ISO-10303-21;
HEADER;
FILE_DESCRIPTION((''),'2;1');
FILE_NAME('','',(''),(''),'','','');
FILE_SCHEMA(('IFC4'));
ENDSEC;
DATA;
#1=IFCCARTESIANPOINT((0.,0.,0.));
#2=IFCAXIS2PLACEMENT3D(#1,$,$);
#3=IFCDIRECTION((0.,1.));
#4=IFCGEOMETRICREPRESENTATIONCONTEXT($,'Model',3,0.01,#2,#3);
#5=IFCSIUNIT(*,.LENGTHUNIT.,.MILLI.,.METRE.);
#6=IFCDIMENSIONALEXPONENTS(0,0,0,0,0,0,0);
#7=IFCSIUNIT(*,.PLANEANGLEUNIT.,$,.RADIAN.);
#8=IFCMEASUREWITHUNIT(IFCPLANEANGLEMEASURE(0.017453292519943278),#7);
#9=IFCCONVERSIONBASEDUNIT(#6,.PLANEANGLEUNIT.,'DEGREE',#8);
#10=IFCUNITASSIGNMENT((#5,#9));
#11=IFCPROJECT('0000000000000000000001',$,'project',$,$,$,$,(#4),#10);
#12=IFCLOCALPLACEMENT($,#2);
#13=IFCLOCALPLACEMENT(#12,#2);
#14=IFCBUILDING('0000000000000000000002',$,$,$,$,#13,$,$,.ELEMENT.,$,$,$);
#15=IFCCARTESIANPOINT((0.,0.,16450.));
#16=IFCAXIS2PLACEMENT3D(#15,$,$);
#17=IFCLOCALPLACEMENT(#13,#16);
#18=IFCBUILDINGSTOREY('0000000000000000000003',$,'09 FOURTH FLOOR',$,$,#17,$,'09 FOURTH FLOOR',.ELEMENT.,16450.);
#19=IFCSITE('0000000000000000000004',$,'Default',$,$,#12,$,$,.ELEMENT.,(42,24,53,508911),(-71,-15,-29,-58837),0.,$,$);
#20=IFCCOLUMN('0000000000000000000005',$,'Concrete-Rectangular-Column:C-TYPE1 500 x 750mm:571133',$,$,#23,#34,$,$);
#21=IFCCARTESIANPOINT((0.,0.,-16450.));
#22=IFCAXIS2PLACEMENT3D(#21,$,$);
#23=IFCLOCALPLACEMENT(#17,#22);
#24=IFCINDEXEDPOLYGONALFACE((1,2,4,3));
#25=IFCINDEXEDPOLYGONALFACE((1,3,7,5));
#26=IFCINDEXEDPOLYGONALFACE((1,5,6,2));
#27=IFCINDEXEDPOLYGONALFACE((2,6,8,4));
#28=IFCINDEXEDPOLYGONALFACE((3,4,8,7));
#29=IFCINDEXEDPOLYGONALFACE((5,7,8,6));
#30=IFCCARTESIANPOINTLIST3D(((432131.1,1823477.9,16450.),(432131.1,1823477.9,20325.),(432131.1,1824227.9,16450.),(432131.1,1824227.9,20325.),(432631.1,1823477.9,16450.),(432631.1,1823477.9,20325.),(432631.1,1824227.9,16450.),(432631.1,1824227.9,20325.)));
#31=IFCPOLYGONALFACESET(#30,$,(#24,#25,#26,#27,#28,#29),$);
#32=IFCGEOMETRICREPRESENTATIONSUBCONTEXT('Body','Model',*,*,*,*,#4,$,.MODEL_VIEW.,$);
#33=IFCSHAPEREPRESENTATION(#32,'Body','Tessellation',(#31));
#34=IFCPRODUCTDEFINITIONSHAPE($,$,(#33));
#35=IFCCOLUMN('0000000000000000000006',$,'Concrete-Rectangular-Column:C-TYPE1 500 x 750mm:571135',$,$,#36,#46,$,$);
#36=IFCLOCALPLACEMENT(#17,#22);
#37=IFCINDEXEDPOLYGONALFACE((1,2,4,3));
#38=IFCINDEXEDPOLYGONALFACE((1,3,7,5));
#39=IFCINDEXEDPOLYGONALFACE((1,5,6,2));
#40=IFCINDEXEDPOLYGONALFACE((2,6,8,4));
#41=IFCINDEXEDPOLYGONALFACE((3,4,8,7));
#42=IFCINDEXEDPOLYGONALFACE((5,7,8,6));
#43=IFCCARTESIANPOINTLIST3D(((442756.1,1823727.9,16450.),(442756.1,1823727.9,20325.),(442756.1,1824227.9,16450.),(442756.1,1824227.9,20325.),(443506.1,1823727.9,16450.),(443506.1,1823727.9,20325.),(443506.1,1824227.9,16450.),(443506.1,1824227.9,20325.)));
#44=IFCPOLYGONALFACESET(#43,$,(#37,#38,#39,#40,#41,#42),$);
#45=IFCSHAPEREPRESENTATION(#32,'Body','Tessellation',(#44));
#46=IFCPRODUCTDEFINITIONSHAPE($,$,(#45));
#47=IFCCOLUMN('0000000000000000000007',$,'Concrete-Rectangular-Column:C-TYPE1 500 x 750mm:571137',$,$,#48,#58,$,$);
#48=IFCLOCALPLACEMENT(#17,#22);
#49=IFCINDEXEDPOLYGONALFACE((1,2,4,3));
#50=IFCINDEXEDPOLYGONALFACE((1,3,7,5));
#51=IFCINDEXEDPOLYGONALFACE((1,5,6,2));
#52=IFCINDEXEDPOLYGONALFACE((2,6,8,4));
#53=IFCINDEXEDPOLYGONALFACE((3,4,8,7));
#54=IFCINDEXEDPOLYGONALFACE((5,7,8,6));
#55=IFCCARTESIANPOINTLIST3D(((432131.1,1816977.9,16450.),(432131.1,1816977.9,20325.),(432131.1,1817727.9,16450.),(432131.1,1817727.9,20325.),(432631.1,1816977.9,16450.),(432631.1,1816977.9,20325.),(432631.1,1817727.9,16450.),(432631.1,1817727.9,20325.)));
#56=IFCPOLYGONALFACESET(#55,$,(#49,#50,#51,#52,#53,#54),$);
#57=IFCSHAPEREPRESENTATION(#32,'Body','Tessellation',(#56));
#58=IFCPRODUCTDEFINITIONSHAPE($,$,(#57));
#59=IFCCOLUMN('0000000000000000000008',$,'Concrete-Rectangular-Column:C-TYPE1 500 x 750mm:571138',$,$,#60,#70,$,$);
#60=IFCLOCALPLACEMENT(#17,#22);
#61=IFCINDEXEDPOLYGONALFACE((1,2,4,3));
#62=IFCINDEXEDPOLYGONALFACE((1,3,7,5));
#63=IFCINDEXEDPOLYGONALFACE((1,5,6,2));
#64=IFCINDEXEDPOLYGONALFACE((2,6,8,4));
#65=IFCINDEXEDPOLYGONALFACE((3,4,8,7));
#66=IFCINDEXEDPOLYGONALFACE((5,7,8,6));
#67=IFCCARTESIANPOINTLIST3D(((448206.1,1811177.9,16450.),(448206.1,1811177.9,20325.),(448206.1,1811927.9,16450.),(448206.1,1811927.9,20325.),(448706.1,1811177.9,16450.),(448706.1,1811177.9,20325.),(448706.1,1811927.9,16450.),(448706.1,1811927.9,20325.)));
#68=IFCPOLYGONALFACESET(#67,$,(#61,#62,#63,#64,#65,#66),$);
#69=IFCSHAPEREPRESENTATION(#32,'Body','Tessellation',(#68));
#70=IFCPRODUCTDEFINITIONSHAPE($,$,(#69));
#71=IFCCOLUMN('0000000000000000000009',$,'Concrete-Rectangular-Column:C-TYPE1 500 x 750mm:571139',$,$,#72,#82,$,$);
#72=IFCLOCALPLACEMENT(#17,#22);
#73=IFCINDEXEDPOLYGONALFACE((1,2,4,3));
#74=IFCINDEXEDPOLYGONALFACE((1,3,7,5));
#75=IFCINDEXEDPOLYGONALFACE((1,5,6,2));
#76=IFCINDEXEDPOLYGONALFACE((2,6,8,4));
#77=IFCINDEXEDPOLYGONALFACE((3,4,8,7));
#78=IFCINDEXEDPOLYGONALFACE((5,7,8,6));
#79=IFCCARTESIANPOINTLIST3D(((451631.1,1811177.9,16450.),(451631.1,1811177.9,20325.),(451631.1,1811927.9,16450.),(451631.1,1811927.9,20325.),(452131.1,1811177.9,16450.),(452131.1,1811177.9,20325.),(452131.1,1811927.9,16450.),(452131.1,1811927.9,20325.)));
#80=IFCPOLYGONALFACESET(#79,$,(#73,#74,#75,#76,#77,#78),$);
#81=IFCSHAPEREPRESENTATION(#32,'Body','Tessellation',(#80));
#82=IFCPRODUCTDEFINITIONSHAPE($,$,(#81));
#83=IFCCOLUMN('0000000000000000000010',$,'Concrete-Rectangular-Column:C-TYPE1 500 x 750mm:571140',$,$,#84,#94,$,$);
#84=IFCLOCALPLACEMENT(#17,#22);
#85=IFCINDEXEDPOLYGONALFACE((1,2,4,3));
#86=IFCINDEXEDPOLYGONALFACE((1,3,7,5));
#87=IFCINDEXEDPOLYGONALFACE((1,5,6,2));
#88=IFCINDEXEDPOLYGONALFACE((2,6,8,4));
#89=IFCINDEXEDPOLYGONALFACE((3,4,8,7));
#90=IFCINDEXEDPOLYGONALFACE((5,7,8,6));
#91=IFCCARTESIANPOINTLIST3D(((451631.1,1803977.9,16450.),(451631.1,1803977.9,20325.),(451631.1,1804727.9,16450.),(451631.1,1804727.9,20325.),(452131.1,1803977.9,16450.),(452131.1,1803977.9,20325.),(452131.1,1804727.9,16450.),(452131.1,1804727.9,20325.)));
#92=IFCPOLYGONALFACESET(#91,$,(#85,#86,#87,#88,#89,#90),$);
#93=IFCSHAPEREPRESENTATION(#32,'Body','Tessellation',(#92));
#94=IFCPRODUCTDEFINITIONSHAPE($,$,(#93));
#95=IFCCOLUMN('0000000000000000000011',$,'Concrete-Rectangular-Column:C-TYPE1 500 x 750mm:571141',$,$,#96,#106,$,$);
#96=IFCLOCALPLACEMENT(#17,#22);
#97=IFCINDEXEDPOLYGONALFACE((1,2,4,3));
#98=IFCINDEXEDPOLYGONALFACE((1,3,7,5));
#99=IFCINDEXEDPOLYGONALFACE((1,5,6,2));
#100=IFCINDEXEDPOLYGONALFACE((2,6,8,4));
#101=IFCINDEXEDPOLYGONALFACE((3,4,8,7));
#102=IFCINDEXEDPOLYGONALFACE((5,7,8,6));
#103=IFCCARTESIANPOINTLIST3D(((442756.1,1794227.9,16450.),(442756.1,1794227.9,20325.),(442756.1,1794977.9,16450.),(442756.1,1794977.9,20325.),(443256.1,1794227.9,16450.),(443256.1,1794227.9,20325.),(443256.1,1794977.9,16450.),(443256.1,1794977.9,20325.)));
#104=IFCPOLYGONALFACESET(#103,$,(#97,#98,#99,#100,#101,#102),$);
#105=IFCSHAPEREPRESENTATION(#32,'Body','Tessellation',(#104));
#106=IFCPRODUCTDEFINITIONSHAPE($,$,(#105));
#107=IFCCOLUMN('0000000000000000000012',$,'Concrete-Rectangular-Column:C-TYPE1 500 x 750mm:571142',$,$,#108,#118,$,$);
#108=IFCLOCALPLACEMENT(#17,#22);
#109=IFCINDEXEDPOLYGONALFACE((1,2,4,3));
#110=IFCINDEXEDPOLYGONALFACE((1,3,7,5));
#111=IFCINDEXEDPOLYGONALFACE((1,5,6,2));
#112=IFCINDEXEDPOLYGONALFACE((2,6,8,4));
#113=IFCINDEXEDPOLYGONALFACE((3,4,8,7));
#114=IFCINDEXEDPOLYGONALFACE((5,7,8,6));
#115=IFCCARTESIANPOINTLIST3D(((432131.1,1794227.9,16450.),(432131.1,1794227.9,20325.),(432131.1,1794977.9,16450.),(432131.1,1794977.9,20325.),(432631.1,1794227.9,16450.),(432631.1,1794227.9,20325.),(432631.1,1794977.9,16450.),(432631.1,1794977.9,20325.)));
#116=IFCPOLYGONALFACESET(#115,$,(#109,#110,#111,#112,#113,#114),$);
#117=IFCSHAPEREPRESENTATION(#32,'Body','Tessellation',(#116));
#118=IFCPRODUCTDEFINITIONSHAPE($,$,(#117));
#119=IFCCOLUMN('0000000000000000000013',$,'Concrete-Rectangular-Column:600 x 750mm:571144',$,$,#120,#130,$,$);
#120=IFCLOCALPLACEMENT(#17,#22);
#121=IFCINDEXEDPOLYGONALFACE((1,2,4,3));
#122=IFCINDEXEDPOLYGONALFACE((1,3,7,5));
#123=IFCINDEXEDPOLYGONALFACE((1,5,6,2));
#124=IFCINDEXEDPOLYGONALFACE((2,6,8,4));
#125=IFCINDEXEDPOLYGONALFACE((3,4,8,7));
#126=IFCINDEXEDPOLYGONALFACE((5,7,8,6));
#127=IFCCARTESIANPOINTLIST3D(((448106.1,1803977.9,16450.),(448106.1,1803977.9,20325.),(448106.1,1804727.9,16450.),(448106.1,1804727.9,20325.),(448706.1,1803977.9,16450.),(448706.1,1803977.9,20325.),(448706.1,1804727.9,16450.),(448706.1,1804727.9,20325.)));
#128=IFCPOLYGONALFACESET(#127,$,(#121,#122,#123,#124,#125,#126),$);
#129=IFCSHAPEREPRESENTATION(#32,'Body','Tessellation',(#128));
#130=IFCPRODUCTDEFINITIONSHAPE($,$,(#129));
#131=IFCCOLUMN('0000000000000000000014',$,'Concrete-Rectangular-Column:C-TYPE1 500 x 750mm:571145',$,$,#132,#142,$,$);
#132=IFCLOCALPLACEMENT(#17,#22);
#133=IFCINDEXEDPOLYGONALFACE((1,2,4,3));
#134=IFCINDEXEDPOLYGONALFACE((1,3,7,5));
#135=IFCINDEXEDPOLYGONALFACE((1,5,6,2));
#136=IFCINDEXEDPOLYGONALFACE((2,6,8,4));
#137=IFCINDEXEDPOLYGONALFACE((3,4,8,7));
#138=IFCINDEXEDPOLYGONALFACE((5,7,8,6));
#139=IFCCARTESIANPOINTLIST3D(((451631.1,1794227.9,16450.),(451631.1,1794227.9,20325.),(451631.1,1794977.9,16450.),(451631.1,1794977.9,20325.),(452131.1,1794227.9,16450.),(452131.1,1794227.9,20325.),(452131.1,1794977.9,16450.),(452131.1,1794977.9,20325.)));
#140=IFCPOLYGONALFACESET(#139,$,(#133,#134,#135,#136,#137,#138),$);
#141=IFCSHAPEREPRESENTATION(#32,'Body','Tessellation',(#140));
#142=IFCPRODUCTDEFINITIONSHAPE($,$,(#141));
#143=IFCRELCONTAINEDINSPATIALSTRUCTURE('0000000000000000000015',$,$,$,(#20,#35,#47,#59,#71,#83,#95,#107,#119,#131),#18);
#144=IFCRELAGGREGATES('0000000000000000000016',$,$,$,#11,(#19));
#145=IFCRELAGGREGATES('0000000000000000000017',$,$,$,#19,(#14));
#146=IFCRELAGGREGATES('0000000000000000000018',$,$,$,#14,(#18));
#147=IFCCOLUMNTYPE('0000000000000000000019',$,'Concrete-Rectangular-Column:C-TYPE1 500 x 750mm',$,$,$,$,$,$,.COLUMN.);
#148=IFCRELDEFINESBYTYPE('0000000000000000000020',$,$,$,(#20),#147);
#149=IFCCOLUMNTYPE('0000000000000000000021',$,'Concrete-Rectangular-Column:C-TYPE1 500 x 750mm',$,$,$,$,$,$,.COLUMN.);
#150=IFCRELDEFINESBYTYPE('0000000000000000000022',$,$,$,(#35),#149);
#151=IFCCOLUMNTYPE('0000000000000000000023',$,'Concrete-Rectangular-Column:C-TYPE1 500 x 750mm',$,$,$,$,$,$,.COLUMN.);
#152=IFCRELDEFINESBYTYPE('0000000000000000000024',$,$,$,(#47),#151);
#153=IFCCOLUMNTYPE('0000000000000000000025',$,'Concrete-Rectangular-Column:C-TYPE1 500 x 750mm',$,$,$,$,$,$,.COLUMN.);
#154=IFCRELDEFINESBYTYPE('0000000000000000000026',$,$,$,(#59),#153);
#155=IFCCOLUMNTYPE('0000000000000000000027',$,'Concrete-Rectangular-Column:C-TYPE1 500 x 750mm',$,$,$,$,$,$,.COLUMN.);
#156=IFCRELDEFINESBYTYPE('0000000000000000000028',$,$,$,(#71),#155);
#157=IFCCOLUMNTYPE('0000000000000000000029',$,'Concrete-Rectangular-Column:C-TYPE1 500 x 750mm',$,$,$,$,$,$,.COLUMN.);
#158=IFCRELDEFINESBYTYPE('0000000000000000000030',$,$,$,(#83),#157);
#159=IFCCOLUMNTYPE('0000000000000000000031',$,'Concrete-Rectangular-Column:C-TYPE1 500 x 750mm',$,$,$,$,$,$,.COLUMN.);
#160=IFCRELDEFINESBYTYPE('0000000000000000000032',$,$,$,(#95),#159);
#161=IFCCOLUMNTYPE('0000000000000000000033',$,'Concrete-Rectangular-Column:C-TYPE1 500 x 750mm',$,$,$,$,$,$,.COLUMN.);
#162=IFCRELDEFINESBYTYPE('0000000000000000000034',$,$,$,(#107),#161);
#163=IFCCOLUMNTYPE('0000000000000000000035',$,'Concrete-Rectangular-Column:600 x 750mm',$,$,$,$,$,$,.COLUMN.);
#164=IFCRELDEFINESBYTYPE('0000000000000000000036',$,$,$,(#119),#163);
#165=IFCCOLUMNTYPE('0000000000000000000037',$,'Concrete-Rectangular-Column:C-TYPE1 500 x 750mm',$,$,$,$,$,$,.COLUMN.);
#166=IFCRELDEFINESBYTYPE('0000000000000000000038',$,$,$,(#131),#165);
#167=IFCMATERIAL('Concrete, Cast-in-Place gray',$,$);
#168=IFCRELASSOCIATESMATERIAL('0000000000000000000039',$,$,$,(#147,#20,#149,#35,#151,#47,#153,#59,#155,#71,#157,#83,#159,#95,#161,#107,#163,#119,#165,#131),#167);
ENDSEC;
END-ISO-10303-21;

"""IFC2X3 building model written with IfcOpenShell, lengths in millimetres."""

from ifc_helpers import new_model, entity, si_unit, converted_unit, direction, frame, frame_2d, origin, place, context, subcontext, project, spatial, rectangle, extrude, source, transform, mapped, material, type_object, type_shapes, element, save


model = new_model("IFC2X3")

# Units and contexts
model_context = context("Model", 3, precision=0.01, world=origin(), true_north=direction((0.0, 1.0)))
body_context = subcontext(model_context, "Body", "Model", "MODEL_VIEW")
ifc_project = project(units=[si_unit("LENGTHUNIT", "METRE", prefix="MILLI"), converted_unit("PLANEANGLEUNIT", "DEGREE", entity("IfcPlaneAngleMeasure", 0.017453292519943278), si_unit("PLANEANGLEUNIT", "RADIAN"), dimensions=[0, 0, 0, 0, 0, 0, 0])], contexts=[model_context])

# Site, building, storey
site_placement = place(None, origin())
site = spatial("IfcSite", under=ifc_project, at=site_placement, Name="Default", CompositionType="ELEMENT", RefLatitude=(42, 24, 53, 508911), RefLongitude=(-71, -15, -29, -58837), RefElevation=0.0)
building_placement = place(site_placement, origin())
building = spatial("IfcBuilding", under=site, at=building_placement, CompositionType="ELEMENT")
storey_placement = place(building_placement, frame((0.0, 0.0, 16450.0)))
storey = spatial("IfcBuildingStorey", under=building, at=storey_placement, Name="09 FOURTH FLOOR", LongName="09 FOURTH FLOOR", CompositionType="ELEMENT", Elevation=16450.0)

# Columns
ifc_material = material(Name="Concrete, Cast-in-Place gray")
column_type_1 = type_object("IfcColumnType", Name="Concrete-Rectangular-Column:C-TYPE1 500 x 750mm", PredefinedType="COLUMN", material=ifc_material)
shared_shape_1 = source(origin(), body_context, "Body", "SweptSolid", [
    extrude(rectangle(XDim=3875.0, YDim=750.0, at=frame_2d((0.0, 0.0), x_axis=(1.0, 0.0))), frame((432131.1, 1823852.9, 18387.5), z_axis=(1.0, 0.0, 0.0), x_axis=(0.0, 0.0, 1.0)), (0.0, 0.0, 1.0), 500.0),
])
type_shapes(column_type_1, [shared_shape_1])
column_1_placement = place(storey_placement, frame((0.0, 0.0, -16450.0)))
element("IfcColumn", 1, at=column_1_placement, inside=storey, type_object=column_type_1, material=ifc_material, Name="Concrete-Rectangular-Column:C-TYPE1 500 x 750mm:571133", context=body_context, shape_type="MappedRepresentation", body=[
    mapped(shared_shape_1, transform((0.0, 0.0, 0.0), scale=1.0)),
])
column_type_2 = type_object("IfcColumnType", Name="Concrete-Rectangular-Column:C-TYPE1 500 x 750mm", PredefinedType="COLUMN", material=ifc_material)
shared_shape_2 = source(origin(), body_context, "Body", "SweptSolid", [
    extrude(rectangle(XDim=500.0, YDim=750.0, at=frame_2d((0.0, 0.0), x_axis=(1.0, 0.0))), frame((443131.1, 1823977.9, 16450.0), z_axis=(0.0, 0.0, 1.0), x_axis=(0.0, -1.0, 0.0)), (0.0, 0.0, 1.0), 3875.0),
])
type_shapes(column_type_2, [shared_shape_2])
column_2_placement = place(storey_placement, frame((0.0, 0.0, -16450.0)))
element("IfcColumn", 2, at=column_2_placement, inside=storey, type_object=column_type_2, material=ifc_material, Name="Concrete-Rectangular-Column:C-TYPE1 500 x 750mm:571135", context=body_context, shape_type="MappedRepresentation", body=[
    mapped(shared_shape_2, transform((0.0, 0.0, 0.0), scale=1.0)),
])
column_type_3 = type_object("IfcColumnType", Name="Concrete-Rectangular-Column:C-TYPE1 500 x 750mm", PredefinedType="COLUMN", material=ifc_material)
shared_shape_3 = source(origin(), body_context, "Body", "SweptSolid", [
    extrude(rectangle(XDim=3875.0, YDim=750.0, at=frame_2d((0.0, 0.0), x_axis=(1.0, 0.0))), frame((432131.1, 1817352.9, 18387.5), z_axis=(1.0, 0.0, 0.0), x_axis=(0.0, 0.0, 1.0)), (0.0, 0.0, 1.0), 500.0),
])
type_shapes(column_type_3, [shared_shape_3])
column_3_placement = place(storey_placement, frame((0.0, 0.0, -16450.0)))
element("IfcColumn", 3, at=column_3_placement, inside=storey, type_object=column_type_3, material=ifc_material, Name="Concrete-Rectangular-Column:C-TYPE1 500 x 750mm:571137", context=body_context, shape_type="MappedRepresentation", body=[
    mapped(shared_shape_3, transform((0.0, 0.0, 0.0), scale=1.0)),
])
column_type_4 = type_object("IfcColumnType", Name="Concrete-Rectangular-Column:C-TYPE1 500 x 750mm", PredefinedType="COLUMN", material=ifc_material)
shared_shape_4 = source(origin(), body_context, "Body", "SweptSolid", [
    extrude(rectangle(XDim=3875.0, YDim=750.0, at=frame_2d((0.0, 0.0), x_axis=(1.0, 0.0))), frame((448206.1, 1811552.9, 18387.5), z_axis=(1.0, 0.0, 0.0), x_axis=(0.0, 0.0, 1.0)), (0.0, 0.0, 1.0), 500.0),
])
type_shapes(column_type_4, [shared_shape_4])
column_4_placement = place(storey_placement, frame((0.0, 0.0, -16450.0)))
element("IfcColumn", 4, at=column_4_placement, inside=storey, type_object=column_type_4, material=ifc_material, Name="Concrete-Rectangular-Column:C-TYPE1 500 x 750mm:571138", context=body_context, shape_type="MappedRepresentation", body=[
    mapped(shared_shape_4, transform((0.0, 0.0, 0.0), scale=1.0)),
])
column_type_5 = type_object("IfcColumnType", Name="Concrete-Rectangular-Column:C-TYPE1 500 x 750mm", PredefinedType="COLUMN", material=ifc_material)
shared_shape_5 = source(origin(), body_context, "Body", "SweptSolid", [
    extrude(rectangle(XDim=3875.0, YDim=750.0, at=frame_2d((0.0, 0.0), x_axis=(1.0, 0.0))), frame((451631.1, 1811552.9, 18387.5), z_axis=(1.0, 0.0, 0.0), x_axis=(0.0, 0.0, 1.0)), (0.0, 0.0, 1.0), 500.0),
])
type_shapes(column_type_5, [shared_shape_5])
column_5_placement = place(storey_placement, frame((0.0, 0.0, -16450.0)))
element("IfcColumn", 5, at=column_5_placement, inside=storey, type_object=column_type_5, material=ifc_material, Name="Concrete-Rectangular-Column:C-TYPE1 500 x 750mm:571139", context=body_context, shape_type="MappedRepresentation", body=[
    mapped(shared_shape_5, transform((0.0, 0.0, 0.0), scale=1.0)),
])
column_type_6 = type_object("IfcColumnType", Name="Concrete-Rectangular-Column:C-TYPE1 500 x 750mm", PredefinedType="COLUMN", material=ifc_material)
shared_shape_6 = source(origin(), body_context, "Body", "SweptSolid", [
    extrude(rectangle(XDim=3875.0, YDim=750.0, at=frame_2d((0.0, 0.0), x_axis=(1.0, 0.0))), frame((451631.1, 1804352.9, 18387.5), z_axis=(1.0, 0.0, 0.0), x_axis=(0.0, 0.0, 1.0)), (0.0, 0.0, 1.0), 500.0),
])
type_shapes(column_type_6, [shared_shape_6])
column_6_placement = place(storey_placement, frame((0.0, 0.0, -16450.0)))
element("IfcColumn", 6, at=column_6_placement, inside=storey, type_object=column_type_6, material=ifc_material, Name="Concrete-Rectangular-Column:C-TYPE1 500 x 750mm:571140", context=body_context, shape_type="MappedRepresentation", body=[
    mapped(shared_shape_6, transform((0.0, 0.0, 0.0), scale=1.0)),
])
column_type_7 = type_object("IfcColumnType", Name="Concrete-Rectangular-Column:C-TYPE1 500 x 750mm", PredefinedType="COLUMN", material=ifc_material)
shared_shape_7 = source(origin(), body_context, "Body", "SweptSolid", [
    extrude(rectangle(XDim=3875.0, YDim=750.0, at=frame_2d((0.0, 0.0), x_axis=(1.0, 0.0))), frame((442756.1, 1794602.9, 18387.5), z_axis=(1.0, 0.0, 0.0), x_axis=(0.0, 0.0, 1.0)), (0.0, 0.0, 1.0), 500.0),
])
type_shapes(column_type_7, [shared_shape_7])
column_7_placement = place(storey_placement, frame((0.0, 0.0, -16450.0)))
element("IfcColumn", 7, at=column_7_placement, inside=storey, type_object=column_type_7, material=ifc_material, Name="Concrete-Rectangular-Column:C-TYPE1 500 x 750mm:571141", context=body_context, shape_type="MappedRepresentation", body=[
    mapped(shared_shape_7, transform((0.0, 0.0, 0.0), scale=1.0)),
])
column_type_8 = type_object("IfcColumnType", Name="Concrete-Rectangular-Column:C-TYPE1 500 x 750mm", PredefinedType="COLUMN", material=ifc_material)
shared_shape_8 = source(origin(), body_context, "Body", "SweptSolid", [
    extrude(rectangle(XDim=3875.0, YDim=750.0, at=frame_2d((0.0, 0.0), x_axis=(1.0, 0.0))), frame((432131.1, 1794602.9, 18387.5), z_axis=(1.0, 0.0, 0.0), x_axis=(0.0, 0.0, 1.0)), (0.0, 0.0, 1.0), 500.0),
])
type_shapes(column_type_8, [shared_shape_8])
column_8_placement = place(storey_placement, frame((0.0, 0.0, -16450.0)))
element("IfcColumn", 8, at=column_8_placement, inside=storey, type_object=column_type_8, material=ifc_material, Name="Concrete-Rectangular-Column:C-TYPE1 500 x 750mm:571142", context=body_context, shape_type="MappedRepresentation", body=[
    mapped(shared_shape_8, transform((0.0, 0.0, 0.0), scale=1.0)),
])
column_type_9 = type_object("IfcColumnType", Name="Concrete-Rectangular-Column:600 x 750mm", PredefinedType="COLUMN", material=ifc_material)
shared_shape_9 = source(origin(), body_context, "Body", "SweptSolid", [
    extrude(rectangle(XDim=3875.0, YDim=750.0, at=frame_2d((0.0, 0.0), x_axis=(1.0, 0.0))), frame((448106.1, 1804352.9, 18387.5), z_axis=(1.0, 0.0, 0.0), x_axis=(0.0, 0.0, 1.0)), (0.0, 0.0, 1.0), 600.0),
])
type_shapes(column_type_9, [shared_shape_9])
column_9_placement = place(storey_placement, frame((0.0, 0.0, -16450.0)))
element("IfcColumn", 9, at=column_9_placement, inside=storey, type_object=column_type_9, material=ifc_material, Name="Concrete-Rectangular-Column:600 x 750mm:571144", context=body_context, shape_type="MappedRepresentation", body=[
    mapped(shared_shape_9, transform((0.0, 0.0, 0.0), scale=1.0)),
])
column_type_10 = type_object("IfcColumnType", Name="Concrete-Rectangular-Column:C-TYPE1 500 x 750mm", PredefinedType="COLUMN", material=ifc_material)
shared_shape_10 = source(origin(), body_context, "Body", "SweptSolid", [
    extrude(rectangle(XDim=3875.0, YDim=750.0, at=frame_2d((0.0, 0.0), x_axis=(1.0, 0.0))), frame((451631.1, 1794602.9, 18387.5), z_axis=(1.0, 0.0, 0.0), x_axis=(0.0, 0.0, 1.0)), (0.0, 0.0, 1.0), 500.0),
])
type_shapes(column_type_10, [shared_shape_10])
column_10_placement = place(storey_placement, frame((0.0, 0.0, -16450.0)))
element("IfcColumn", 10, at=column_10_placement, inside=storey, type_object=column_type_10, material=ifc_material, Name="Concrete-Rectangular-Column:C-TYPE1 500 x 750mm:571145", context=body_context, shape_type="MappedRepresentation", body=[
    mapped(shared_shape_10, transform((0.0, 0.0, 0.0), scale=1.0)),
])

save(model, "model.ifc")
